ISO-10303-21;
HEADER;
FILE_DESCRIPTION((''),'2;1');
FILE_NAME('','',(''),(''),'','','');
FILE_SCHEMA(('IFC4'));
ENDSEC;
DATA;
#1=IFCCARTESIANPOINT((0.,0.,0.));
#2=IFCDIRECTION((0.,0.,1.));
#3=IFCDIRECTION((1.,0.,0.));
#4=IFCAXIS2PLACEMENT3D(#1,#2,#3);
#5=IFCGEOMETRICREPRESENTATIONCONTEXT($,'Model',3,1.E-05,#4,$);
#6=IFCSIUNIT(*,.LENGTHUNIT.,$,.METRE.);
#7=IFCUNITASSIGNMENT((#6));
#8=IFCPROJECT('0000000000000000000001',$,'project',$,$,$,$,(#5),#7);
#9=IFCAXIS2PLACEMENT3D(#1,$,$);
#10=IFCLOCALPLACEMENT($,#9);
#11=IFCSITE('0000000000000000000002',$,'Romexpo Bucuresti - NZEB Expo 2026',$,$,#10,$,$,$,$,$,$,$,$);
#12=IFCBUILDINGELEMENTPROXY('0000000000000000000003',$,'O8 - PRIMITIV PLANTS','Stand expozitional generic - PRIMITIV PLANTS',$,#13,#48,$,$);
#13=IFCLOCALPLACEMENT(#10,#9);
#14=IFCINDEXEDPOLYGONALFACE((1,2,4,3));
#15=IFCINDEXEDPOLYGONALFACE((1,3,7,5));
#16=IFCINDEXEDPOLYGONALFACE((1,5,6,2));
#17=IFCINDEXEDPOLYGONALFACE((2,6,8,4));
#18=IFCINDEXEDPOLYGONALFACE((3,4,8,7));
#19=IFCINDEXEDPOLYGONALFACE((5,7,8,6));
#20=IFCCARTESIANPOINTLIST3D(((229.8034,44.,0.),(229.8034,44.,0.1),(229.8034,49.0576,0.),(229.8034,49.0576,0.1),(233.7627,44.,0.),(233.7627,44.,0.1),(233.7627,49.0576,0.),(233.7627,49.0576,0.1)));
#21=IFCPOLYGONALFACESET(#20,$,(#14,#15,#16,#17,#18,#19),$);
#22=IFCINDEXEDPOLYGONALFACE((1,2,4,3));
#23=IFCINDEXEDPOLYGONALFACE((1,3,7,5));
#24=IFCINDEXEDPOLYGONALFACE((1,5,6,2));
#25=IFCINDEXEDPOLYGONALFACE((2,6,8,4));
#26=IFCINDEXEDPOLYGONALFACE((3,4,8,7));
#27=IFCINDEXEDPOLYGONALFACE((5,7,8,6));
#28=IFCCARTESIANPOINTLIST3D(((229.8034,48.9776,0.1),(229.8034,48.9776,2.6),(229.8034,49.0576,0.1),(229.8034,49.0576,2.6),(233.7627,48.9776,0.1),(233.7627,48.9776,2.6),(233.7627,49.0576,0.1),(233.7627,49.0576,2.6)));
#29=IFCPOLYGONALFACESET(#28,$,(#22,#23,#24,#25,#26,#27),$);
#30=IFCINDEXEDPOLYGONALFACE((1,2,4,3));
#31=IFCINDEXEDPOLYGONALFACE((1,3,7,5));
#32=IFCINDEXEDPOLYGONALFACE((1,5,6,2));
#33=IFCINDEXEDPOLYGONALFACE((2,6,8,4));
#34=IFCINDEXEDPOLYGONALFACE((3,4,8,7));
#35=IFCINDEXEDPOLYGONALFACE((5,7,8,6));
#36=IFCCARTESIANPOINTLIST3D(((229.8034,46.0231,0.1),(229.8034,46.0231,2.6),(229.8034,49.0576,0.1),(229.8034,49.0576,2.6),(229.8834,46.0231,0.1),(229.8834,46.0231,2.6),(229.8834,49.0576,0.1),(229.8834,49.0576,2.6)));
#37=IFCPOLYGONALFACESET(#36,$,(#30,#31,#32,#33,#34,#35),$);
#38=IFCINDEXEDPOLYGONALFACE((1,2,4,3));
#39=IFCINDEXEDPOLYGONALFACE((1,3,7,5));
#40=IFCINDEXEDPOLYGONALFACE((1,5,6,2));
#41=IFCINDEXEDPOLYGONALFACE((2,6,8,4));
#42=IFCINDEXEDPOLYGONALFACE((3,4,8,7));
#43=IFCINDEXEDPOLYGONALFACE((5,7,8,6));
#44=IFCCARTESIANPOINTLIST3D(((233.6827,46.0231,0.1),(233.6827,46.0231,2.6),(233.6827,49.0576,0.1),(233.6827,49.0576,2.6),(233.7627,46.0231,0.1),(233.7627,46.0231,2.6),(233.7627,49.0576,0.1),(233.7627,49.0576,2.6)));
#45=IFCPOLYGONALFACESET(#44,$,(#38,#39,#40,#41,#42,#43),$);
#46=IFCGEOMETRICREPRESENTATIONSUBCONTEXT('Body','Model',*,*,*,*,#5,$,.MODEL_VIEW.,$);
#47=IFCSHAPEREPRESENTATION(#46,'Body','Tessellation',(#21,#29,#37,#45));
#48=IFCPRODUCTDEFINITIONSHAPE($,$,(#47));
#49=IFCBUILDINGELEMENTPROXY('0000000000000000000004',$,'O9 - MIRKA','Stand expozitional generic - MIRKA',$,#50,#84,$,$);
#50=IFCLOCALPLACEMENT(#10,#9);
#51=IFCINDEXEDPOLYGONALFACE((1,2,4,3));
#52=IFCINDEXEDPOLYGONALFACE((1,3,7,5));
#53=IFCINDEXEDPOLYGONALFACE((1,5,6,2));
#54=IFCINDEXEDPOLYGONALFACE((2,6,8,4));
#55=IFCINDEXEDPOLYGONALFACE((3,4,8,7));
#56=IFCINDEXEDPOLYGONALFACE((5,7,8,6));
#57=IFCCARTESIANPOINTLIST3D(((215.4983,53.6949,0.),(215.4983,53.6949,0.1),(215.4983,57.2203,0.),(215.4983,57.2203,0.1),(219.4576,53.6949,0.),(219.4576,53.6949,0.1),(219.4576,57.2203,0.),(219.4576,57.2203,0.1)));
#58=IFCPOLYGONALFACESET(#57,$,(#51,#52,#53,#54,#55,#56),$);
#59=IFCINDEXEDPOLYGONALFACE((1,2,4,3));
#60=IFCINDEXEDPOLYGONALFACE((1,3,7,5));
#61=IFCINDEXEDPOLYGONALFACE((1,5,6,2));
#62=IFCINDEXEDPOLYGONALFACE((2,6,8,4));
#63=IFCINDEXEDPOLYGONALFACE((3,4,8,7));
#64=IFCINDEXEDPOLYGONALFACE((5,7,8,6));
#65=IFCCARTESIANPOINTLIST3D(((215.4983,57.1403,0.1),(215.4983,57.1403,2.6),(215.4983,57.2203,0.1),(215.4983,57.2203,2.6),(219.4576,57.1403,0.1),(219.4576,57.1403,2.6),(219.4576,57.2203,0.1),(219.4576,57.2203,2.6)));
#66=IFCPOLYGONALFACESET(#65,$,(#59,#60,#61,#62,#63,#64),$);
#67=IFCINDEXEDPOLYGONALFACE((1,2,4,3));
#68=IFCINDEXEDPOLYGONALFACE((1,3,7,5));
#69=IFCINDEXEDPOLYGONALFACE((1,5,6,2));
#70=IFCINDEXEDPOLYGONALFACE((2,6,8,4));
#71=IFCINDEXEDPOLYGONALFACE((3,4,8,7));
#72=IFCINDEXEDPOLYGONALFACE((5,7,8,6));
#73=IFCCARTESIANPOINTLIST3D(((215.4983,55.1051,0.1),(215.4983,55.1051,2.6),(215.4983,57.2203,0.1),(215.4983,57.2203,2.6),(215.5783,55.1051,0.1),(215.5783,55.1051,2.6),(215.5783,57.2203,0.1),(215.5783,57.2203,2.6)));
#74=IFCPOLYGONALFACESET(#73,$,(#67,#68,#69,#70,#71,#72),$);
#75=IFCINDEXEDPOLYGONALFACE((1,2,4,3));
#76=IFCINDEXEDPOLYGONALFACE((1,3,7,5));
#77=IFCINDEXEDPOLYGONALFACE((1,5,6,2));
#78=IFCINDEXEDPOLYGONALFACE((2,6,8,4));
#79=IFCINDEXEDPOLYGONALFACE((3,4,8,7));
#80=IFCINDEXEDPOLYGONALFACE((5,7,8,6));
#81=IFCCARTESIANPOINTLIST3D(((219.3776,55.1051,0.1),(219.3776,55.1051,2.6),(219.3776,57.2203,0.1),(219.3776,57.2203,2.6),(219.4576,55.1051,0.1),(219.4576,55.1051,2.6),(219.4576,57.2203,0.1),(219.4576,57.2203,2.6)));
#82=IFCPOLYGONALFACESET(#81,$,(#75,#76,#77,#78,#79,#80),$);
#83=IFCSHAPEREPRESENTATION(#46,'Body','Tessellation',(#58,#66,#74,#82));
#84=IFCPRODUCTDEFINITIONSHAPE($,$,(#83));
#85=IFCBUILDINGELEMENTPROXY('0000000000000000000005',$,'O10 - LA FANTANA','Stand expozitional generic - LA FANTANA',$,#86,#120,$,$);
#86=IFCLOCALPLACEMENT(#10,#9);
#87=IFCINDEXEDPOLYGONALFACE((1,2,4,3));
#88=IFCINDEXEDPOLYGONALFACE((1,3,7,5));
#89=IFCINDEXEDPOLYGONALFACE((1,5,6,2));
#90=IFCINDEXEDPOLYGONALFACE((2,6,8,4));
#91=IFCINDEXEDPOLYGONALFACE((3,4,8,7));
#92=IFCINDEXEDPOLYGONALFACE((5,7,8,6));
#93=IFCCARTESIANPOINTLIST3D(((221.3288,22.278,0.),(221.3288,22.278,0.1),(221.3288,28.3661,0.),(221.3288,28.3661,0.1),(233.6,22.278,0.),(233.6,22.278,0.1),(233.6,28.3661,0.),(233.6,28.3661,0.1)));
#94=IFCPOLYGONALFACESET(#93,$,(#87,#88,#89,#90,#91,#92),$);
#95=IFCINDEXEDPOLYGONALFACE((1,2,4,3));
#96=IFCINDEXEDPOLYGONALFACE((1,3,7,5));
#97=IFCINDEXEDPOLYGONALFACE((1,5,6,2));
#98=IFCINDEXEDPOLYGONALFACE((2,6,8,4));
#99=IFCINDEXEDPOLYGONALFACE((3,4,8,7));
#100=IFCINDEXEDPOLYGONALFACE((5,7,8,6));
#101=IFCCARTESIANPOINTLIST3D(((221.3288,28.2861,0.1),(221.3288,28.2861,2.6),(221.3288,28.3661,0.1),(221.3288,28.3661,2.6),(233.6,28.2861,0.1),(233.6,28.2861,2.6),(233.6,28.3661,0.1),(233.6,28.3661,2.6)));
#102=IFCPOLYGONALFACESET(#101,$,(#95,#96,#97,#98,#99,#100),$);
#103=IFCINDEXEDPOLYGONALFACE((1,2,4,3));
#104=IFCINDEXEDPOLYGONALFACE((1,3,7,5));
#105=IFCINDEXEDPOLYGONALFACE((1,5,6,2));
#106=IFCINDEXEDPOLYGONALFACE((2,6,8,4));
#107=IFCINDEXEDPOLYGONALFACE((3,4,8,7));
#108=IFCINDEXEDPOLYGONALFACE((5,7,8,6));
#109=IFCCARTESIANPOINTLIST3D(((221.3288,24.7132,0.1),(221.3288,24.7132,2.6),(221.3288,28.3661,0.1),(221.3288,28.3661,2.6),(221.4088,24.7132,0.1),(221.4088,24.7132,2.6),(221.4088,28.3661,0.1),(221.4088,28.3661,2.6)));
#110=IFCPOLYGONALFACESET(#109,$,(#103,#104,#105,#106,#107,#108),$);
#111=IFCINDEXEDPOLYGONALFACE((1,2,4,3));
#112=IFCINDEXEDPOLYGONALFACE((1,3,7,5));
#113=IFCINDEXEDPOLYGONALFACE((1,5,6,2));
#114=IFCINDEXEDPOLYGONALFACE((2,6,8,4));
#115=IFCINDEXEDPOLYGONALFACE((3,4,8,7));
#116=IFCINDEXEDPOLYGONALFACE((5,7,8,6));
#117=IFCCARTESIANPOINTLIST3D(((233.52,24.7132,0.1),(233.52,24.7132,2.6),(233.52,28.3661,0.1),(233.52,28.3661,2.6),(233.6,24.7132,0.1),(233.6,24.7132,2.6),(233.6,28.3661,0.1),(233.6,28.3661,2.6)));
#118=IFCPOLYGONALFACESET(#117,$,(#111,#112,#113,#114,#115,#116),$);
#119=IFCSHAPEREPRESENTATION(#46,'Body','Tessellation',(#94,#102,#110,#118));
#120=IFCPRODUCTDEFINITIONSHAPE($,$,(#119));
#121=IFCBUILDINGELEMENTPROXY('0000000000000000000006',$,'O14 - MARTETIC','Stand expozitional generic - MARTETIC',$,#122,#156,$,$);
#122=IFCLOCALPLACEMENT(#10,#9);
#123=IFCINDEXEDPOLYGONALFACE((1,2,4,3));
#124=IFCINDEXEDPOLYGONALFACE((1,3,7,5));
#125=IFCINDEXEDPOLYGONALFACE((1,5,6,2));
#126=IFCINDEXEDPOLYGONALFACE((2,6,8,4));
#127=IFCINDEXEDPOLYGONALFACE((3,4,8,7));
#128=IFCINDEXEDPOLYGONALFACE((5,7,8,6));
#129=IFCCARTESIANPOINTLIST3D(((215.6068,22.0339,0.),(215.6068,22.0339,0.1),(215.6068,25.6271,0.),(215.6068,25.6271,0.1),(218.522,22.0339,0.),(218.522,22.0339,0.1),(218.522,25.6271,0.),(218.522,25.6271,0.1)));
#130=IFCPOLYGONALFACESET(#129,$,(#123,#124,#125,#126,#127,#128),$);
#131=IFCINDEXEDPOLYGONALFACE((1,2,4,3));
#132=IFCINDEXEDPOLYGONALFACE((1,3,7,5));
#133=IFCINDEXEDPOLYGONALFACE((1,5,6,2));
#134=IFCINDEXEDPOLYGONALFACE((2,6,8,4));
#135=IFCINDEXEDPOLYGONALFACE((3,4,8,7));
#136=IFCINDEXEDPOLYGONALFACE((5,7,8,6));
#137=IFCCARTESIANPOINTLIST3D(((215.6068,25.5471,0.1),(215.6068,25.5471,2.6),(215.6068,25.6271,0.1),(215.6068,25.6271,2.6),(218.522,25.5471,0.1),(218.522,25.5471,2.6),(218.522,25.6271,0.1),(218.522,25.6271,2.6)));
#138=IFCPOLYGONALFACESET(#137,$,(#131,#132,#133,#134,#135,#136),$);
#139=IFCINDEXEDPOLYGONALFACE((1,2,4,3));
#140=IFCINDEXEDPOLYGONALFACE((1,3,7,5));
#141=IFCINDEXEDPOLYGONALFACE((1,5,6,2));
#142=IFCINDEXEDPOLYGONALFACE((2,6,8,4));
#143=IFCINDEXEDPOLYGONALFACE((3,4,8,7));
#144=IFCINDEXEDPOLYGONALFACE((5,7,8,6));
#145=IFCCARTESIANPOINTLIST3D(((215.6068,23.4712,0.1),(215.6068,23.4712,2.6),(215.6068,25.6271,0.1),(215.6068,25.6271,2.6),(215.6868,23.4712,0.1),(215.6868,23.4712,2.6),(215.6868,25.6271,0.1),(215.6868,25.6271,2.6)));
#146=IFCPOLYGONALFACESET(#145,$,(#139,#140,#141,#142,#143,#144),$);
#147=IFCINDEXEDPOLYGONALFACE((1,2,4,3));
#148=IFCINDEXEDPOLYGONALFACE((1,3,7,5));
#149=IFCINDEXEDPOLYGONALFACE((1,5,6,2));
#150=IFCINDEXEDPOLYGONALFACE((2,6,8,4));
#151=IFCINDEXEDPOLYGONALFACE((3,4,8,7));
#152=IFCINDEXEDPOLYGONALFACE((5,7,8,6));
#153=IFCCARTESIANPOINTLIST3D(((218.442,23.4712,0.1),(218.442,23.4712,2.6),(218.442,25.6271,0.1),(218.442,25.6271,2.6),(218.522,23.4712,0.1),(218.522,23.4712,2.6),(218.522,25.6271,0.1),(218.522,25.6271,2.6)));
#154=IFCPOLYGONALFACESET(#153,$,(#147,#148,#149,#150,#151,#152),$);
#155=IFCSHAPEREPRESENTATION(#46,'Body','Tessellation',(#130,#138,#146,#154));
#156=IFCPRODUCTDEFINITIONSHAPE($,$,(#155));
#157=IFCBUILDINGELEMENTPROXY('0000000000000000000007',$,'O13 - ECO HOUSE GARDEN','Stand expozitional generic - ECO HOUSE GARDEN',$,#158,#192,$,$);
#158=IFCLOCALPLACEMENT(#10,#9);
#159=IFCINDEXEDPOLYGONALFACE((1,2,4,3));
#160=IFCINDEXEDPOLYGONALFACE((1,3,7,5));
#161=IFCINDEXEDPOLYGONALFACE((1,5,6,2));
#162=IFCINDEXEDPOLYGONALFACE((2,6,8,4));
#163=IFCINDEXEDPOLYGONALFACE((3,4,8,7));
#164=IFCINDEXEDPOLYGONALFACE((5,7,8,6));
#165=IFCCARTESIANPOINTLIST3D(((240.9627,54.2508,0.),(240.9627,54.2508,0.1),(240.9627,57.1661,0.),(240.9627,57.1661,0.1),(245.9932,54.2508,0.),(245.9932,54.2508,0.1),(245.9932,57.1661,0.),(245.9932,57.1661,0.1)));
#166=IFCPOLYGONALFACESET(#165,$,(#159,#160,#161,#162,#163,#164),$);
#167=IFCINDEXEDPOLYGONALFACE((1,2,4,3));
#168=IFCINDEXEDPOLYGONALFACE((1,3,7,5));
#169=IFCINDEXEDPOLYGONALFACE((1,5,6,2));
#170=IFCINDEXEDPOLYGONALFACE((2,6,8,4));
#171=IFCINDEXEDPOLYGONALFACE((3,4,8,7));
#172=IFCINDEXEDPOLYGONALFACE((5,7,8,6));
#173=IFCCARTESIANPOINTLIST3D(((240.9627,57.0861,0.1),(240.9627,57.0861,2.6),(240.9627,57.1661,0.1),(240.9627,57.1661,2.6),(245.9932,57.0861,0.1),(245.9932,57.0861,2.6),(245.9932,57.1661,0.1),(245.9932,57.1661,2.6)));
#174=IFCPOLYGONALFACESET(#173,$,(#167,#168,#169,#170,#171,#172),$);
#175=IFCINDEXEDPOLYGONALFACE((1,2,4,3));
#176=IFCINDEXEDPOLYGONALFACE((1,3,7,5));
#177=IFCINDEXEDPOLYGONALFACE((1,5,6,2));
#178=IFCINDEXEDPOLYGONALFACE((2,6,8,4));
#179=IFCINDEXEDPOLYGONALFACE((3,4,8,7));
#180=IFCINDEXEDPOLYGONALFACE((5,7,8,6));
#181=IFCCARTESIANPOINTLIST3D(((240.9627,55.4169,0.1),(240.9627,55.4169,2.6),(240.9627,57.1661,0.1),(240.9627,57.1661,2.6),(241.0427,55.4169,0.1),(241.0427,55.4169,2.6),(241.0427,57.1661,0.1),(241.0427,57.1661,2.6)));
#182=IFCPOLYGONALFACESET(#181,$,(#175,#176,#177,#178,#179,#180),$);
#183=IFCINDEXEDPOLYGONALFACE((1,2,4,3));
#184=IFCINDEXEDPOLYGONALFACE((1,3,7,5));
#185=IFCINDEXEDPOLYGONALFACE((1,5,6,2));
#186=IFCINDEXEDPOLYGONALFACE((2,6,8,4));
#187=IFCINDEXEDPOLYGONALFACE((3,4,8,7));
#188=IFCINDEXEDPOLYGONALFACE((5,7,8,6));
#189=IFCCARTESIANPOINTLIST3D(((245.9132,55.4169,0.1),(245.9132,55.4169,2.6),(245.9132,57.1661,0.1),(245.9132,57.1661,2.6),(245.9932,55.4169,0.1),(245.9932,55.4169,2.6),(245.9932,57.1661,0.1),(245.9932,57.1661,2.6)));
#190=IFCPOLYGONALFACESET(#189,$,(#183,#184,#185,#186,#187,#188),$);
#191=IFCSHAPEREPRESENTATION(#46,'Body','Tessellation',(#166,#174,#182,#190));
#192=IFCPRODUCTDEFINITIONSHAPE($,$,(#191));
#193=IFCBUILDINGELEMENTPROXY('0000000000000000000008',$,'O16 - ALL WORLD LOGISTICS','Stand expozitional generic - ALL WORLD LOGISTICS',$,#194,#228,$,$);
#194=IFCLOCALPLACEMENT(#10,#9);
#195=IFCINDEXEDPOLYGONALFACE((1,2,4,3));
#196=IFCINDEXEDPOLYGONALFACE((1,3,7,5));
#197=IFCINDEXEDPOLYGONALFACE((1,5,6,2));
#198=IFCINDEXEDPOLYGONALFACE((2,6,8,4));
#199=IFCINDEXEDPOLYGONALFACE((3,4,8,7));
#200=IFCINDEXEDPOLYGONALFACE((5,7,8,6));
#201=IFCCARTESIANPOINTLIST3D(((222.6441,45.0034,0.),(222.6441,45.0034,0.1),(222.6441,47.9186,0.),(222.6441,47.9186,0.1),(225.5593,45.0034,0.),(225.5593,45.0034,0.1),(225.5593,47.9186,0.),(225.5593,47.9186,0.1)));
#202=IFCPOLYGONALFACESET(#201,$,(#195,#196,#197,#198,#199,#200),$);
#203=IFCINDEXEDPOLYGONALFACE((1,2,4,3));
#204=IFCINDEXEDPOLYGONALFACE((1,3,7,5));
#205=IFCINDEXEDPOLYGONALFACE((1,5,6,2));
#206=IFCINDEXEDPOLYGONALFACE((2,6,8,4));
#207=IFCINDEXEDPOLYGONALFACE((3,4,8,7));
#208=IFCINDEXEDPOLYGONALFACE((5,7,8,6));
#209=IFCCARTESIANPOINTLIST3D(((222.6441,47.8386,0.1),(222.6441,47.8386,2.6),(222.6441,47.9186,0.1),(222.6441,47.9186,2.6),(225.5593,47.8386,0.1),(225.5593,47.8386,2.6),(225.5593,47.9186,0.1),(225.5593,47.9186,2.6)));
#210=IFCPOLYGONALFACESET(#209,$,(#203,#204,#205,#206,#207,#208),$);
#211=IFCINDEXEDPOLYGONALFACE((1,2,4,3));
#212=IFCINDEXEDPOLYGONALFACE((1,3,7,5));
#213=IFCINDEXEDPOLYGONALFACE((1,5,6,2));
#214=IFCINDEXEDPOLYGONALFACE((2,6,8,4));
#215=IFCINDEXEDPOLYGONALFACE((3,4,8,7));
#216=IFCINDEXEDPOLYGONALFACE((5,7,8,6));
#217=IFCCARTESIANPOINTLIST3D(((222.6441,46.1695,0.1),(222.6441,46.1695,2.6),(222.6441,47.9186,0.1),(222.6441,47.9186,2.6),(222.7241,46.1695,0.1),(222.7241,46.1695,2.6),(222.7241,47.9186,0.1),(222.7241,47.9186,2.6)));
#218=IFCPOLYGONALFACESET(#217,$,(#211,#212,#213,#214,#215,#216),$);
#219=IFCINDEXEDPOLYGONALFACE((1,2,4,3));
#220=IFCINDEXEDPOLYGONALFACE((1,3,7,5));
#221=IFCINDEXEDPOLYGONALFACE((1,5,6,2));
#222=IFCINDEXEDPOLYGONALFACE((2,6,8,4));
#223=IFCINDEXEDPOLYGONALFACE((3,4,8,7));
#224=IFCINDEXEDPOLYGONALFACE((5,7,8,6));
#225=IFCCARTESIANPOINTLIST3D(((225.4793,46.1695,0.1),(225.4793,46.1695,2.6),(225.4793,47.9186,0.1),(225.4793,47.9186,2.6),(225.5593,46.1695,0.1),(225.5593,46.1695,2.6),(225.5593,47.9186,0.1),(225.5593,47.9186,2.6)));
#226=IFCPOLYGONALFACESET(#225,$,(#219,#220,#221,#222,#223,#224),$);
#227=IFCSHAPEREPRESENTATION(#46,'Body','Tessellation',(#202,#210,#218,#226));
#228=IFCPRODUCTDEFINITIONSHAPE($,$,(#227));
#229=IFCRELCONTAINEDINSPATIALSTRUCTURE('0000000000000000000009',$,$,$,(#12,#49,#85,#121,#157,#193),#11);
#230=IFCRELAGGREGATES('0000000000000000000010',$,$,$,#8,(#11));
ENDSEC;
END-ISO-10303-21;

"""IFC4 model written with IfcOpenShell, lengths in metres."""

from ifc_helpers import new_model, si_unit, frame, frame_2d, origin, origin_with_axes, place, context, subcontext, project, spatial, rectangle, extrude, element, save


model = new_model("IFC4")

# Units and contexts
model_context = context("Model", 3, precision=1e-05, world=origin_with_axes())
body_context = subcontext(model_context, "Body", "Model", "MODEL_VIEW")
ifc_project = project(units=[si_unit("LENGTHUNIT", "METRE")], contexts=[model_context])

# Site
site_placement = place(None, origin())
site = spatial("IfcSite", under=ifc_project, at=site_placement, Name="Romexpo Bucuresti - NZEB Expo 2026")

# Building element proxies
proxy_1_placement = place(site_placement, frame((229.8034, 44.0, 0.0), z_axis=(0.0, 0.0, 1.0), x_axis=(1.0, 0.0, 0.0)))
element("IfcBuildingElementProxy", 1, at=proxy_1_placement, inside=site, Name="O8 - PRIMITIV PLANTS", Description="Stand expozitional generic - PRIMITIV PLANTS", context=body_context, shape_type="SweptSolid", body=[
    extrude(rectangle(XDim=3.9593, YDim=5.0576, at=frame_2d((1.9797, 2.5288))), origin(), (0.0, 0.0, 1.0), 0.1),
    extrude(rectangle(XDim=3.9593, YDim=0.08, at=frame_2d((1.9797, 5.0176))), frame((0.0, 0.0, 0.1)), (0.0, 0.0, 1.0), 2.5),
    extrude(rectangle(XDim=0.08, YDim=3.0346, at=frame_2d((0.04, 3.5403))), frame((0.0, 0.0, 0.1)), (0.0, 0.0, 1.0), 2.5),
    extrude(rectangle(XDim=0.08, YDim=3.0346, at=frame_2d((3.9193, 3.5403))), frame((0.0, 0.0, 0.1)), (0.0, 0.0, 1.0), 2.5),
])
proxy_2_placement = place(site_placement, frame((215.4983, 53.6949, 0.0), z_axis=(0.0, 0.0, 1.0), x_axis=(1.0, 0.0, 0.0)))
element("IfcBuildingElementProxy", 2, at=proxy_2_placement, inside=site, Name="O9 - MIRKA", Description="Stand expozitional generic - MIRKA", context=body_context, shape_type="SweptSolid", body=[
    extrude(rectangle(XDim=3.9593, YDim=3.5254, at=frame_2d((1.9797, 1.7627))), origin(), (0.0, 0.0, 1.0), 0.1),
    extrude(rectangle(XDim=3.9593, YDim=0.08, at=frame_2d((1.9797, 3.4854))), frame((0.0, 0.0, 0.1)), (0.0, 0.0, 1.0), 2.5),
    extrude(rectangle(XDim=0.08, YDim=2.1153, at=frame_2d((0.04, 2.4678))), frame((0.0, 0.0, 0.1)), (0.0, 0.0, 1.0), 2.5),
    extrude(rectangle(XDim=0.08, YDim=2.1153, at=frame_2d((3.9193, 2.4678))), frame((0.0, 0.0, 0.1)), (0.0, 0.0, 1.0), 2.5),
])
proxy_3_placement = place(site_placement, frame((221.3288, 22.278, 0.0), z_axis=(0.0, 0.0, 1.0), x_axis=(1.0, 0.0, 0.0)))
element("IfcBuildingElementProxy", 3, at=proxy_3_placement, inside=site, Name="O10 - LA FANTANA", Description="Stand expozitional generic - LA FANTANA", context=body_context, shape_type="SweptSolid", body=[
    extrude(rectangle(XDim=12.2712, YDim=6.0881, at=frame_2d((6.1356, 3.0441))), origin(), (0.0, 0.0, 1.0), 0.1),
    extrude(rectangle(XDim=12.2712, YDim=0.08, at=frame_2d((6.1356, 6.0481))), frame((0.0, 0.0, 0.1)), (0.0, 0.0, 1.0), 2.5),
    extrude(rectangle(XDim=0.08, YDim=3.6529, at=frame_2d((0.04, 4.2617))), frame((0.0, 0.0, 0.1)), (0.0, 0.0, 1.0), 2.5),
    extrude(rectangle(XDim=0.08, YDim=3.6529, at=frame_2d((12.2312, 4.2617))), frame((0.0, 0.0, 0.1)), (0.0, 0.0, 1.0), 2.5),
])
proxy_4_placement = place(site_placement, frame((215.6068, 22.0339, 0.0), z_axis=(0.0, 0.0, 1.0), x_axis=(1.0, 0.0, 0.0)))
element("IfcBuildingElementProxy", 4, at=proxy_4_placement, inside=site, Name="O14 - MARTETIC", Description="Stand expozitional generic - MARTETIC", context=body_context, shape_type="SweptSolid", body=[
    extrude(rectangle(XDim=2.9153, YDim=3.5932, at=frame_2d((1.4576, 1.7966))), origin(), (0.0, 0.0, 1.0), 0.1),
    extrude(rectangle(XDim=2.9153, YDim=0.08, at=frame_2d((1.4576, 3.5532))), frame((0.0, 0.0, 0.1)), (0.0, 0.0, 1.0), 2.5),
    extrude(rectangle(XDim=0.08, YDim=2.1559, at=frame_2d((0.04, 2.5153))), frame((0.0, 0.0, 0.1)), (0.0, 0.0, 1.0), 2.5),
    extrude(rectangle(XDim=0.08, YDim=2.1559, at=frame_2d((2.8753, 2.5153))), frame((0.0, 0.0, 0.1)), (0.0, 0.0, 1.0), 2.5),
])
proxy_5_placement = place(site_placement, frame((240.9627, 54.2508, 0.0), z_axis=(0.0, 0.0, 1.0), x_axis=(1.0, 0.0, 0.0)))
element("IfcBuildingElementProxy", 5, at=proxy_5_placement, inside=site, Name="O13 - ECO HOUSE GARDEN", Description="Stand expozitional generic - ECO HOUSE GARDEN", context=body_context, shape_type="SweptSolid", body=[
    extrude(rectangle(XDim=5.0305, YDim=2.9153, at=frame_2d((2.5153, 1.4576))), origin(), (0.0, 0.0, 1.0), 0.1),
    extrude(rectangle(XDim=5.0305, YDim=0.08, at=frame_2d((2.5153, 2.8753))), frame((0.0, 0.0, 0.1)), (0.0, 0.0, 1.0), 2.5),
    extrude(rectangle(XDim=0.08, YDim=1.7492, at=frame_2d((0.04, 2.0407))), frame((0.0, 0.0, 0.1)), (0.0, 0.0, 1.0), 2.5),
    extrude(rectangle(XDim=0.08, YDim=1.7492, at=frame_2d((4.9905, 2.0407))), frame((0.0, 0.0, 0.1)), (0.0, 0.0, 1.0), 2.5),
])
proxy_6_placement = place(site_placement, frame((222.6441, 45.0034, 0.0), z_axis=(0.0, 0.0, 1.0), x_axis=(1.0, 0.0, 0.0)))
element("IfcBuildingElementProxy", 6, at=proxy_6_placement, inside=site, Name="O16 - ALL WORLD LOGISTICS", Description="Stand expozitional generic - ALL WORLD LOGISTICS", context=body_context, shape_type="SweptSolid", body=[
    extrude(rectangle(XDim=2.9153, YDim=2.9153, at=frame_2d((1.4576, 1.4576))), origin(), (0.0, 0.0, 1.0), 0.1),
    extrude(rectangle(XDim=2.9153, YDim=0.08, at=frame_2d((1.4576, 2.8753))), frame((0.0, 0.0, 0.1)), (0.0, 0.0, 1.0), 2.5),
    extrude(rectangle(XDim=0.08, YDim=1.7492, at=frame_2d((0.04, 2.0407))), frame((0.0, 0.0, 0.1)), (0.0, 0.0, 1.0), 2.5),
    extrude(rectangle(XDim=0.08, YDim=1.7492, at=frame_2d((2.8753, 2.0407))), frame((0.0, 0.0, 0.1)), (0.0, 0.0, 1.0), 2.5),
])

save(model, "model.ifc")
